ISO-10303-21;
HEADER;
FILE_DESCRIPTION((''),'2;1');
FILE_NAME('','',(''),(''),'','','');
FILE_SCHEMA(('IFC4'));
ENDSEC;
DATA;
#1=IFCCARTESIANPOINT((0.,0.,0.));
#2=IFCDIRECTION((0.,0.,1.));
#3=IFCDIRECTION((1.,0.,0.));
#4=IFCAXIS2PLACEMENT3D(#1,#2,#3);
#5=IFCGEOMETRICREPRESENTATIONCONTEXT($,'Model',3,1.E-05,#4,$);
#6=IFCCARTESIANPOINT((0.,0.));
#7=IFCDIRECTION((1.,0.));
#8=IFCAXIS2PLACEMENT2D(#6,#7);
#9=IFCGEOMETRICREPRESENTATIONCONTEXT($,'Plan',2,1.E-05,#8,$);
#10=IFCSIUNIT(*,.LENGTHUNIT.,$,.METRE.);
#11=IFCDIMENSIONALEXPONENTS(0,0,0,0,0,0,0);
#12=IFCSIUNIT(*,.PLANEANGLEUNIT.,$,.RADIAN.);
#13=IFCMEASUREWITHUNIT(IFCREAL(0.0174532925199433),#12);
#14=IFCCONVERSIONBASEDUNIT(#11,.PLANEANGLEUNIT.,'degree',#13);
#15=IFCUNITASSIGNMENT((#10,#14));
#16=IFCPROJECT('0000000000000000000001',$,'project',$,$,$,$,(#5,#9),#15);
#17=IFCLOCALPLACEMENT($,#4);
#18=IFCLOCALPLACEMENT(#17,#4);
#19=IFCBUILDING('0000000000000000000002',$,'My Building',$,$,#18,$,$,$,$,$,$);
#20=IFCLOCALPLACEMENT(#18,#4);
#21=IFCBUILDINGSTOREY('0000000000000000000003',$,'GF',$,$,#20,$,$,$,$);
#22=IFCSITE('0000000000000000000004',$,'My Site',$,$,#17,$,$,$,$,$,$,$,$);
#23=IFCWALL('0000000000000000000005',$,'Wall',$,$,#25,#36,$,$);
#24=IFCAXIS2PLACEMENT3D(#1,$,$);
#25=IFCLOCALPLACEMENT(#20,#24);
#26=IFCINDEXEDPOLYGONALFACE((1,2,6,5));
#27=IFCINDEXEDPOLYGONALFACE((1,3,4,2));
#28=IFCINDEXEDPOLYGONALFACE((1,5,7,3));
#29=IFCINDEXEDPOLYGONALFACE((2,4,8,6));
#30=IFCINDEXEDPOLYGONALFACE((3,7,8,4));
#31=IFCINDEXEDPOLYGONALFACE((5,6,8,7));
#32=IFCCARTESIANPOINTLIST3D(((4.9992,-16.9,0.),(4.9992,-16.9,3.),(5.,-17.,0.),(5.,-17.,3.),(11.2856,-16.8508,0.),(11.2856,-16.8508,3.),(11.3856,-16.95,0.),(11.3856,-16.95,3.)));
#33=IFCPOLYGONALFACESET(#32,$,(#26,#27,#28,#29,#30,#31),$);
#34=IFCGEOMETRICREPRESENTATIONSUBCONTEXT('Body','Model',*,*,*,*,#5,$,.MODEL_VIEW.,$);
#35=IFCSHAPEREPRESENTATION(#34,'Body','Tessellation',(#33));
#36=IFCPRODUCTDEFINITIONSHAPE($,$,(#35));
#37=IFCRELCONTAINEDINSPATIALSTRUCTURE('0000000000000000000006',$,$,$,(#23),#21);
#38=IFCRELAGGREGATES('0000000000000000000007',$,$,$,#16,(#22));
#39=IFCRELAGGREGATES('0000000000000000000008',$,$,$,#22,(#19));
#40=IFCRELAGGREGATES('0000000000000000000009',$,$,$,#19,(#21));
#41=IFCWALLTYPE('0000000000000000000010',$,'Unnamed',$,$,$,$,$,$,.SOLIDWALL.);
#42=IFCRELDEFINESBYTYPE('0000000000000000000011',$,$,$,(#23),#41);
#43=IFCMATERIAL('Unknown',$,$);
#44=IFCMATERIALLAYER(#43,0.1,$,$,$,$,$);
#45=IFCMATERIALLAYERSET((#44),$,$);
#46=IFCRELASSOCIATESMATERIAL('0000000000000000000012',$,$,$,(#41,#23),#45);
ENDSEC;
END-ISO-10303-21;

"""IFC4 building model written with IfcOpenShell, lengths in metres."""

from ifc_helpers import new_model, entity, si_unit, converted_unit, frame, origin_with_axes, origin_2d_with_axis, place, context, subcontext, project, spatial, line, indexed_curve, outline, extrude, material, layer, layer_set, layer_usage, type_object, element, save


model = new_model("IFC4")

# Units and contexts
model_context = context("Model", 3, precision=1e-05, world=origin_with_axes())
plan_context = context("Plan", 2, precision=1e-05, world=origin_2d_with_axis())
body_context_1 = subcontext(model_context, "Body", "Model", "MODEL_VIEW")
ifc_project = project(units=[si_unit("LENGTHUNIT", "METRE"), converted_unit("PLANEANGLEUNIT", "degree", entity("IfcReal", 0.0174532925199433), si_unit("PLANEANGLEUNIT", "RADIAN"), dimensions=[0, 0, 0, 0, 0, 0, 0])], contexts=[model_context, plan_context])

# Site, building, storey
site_placement = place(None, origin_with_axes())
site = spatial("IfcSite", under=ifc_project, at=site_placement, Name="My Site")
building_placement = place(site_placement, origin_with_axes())
building = spatial("IfcBuilding", under=site, at=building_placement, Name="My Building")
storey_placement = place(building_placement, origin_with_axes())
storey = spatial("IfcBuildingStorey", under=building, at=storey_placement, Name="GF")

# Shared definitions
ifc_material = material(Name="Unknown")

# Shared definitions
ifc_layer_1 = layer(ifc_material, 0.1)
ifc_layer_set_1 = layer_set([ifc_layer_1])
wall_type = type_object("IfcWallType", Name="Unnamed", PredefinedType="SOLIDWALL", material=ifc_layer_set_1)

# Wall
ifc_layer_usage_1 = layer_usage(ifc_layer_set_1, "AXIS2", "POSITIVE", 0.0)
wall_1_placement = place(storey_placement, frame((5.0, -17.0, 0.0), z_axis=(0.0, 0.0, 1.0), x_axis=(0.999969, 0.007828, 0.0)))
element("IfcWall", 1, at=wall_1_placement, inside=storey, type_object=wall_type, material=ifc_layer_usage_1, Name="Wall", context=body_context_1, shape_type="SweptSolid", body=[
    extrude(outline(indexed_curve([(0.0, 0.0), (0.0, 0.1), (6.2865, 0.1), (6.3858, 0.0)], segments=[line(1, 2, 3, 4, 1)])), origin_with_axes(), (0.0, 0.0, 1.0), 3.0),
])

save(model, "model.ifc")
